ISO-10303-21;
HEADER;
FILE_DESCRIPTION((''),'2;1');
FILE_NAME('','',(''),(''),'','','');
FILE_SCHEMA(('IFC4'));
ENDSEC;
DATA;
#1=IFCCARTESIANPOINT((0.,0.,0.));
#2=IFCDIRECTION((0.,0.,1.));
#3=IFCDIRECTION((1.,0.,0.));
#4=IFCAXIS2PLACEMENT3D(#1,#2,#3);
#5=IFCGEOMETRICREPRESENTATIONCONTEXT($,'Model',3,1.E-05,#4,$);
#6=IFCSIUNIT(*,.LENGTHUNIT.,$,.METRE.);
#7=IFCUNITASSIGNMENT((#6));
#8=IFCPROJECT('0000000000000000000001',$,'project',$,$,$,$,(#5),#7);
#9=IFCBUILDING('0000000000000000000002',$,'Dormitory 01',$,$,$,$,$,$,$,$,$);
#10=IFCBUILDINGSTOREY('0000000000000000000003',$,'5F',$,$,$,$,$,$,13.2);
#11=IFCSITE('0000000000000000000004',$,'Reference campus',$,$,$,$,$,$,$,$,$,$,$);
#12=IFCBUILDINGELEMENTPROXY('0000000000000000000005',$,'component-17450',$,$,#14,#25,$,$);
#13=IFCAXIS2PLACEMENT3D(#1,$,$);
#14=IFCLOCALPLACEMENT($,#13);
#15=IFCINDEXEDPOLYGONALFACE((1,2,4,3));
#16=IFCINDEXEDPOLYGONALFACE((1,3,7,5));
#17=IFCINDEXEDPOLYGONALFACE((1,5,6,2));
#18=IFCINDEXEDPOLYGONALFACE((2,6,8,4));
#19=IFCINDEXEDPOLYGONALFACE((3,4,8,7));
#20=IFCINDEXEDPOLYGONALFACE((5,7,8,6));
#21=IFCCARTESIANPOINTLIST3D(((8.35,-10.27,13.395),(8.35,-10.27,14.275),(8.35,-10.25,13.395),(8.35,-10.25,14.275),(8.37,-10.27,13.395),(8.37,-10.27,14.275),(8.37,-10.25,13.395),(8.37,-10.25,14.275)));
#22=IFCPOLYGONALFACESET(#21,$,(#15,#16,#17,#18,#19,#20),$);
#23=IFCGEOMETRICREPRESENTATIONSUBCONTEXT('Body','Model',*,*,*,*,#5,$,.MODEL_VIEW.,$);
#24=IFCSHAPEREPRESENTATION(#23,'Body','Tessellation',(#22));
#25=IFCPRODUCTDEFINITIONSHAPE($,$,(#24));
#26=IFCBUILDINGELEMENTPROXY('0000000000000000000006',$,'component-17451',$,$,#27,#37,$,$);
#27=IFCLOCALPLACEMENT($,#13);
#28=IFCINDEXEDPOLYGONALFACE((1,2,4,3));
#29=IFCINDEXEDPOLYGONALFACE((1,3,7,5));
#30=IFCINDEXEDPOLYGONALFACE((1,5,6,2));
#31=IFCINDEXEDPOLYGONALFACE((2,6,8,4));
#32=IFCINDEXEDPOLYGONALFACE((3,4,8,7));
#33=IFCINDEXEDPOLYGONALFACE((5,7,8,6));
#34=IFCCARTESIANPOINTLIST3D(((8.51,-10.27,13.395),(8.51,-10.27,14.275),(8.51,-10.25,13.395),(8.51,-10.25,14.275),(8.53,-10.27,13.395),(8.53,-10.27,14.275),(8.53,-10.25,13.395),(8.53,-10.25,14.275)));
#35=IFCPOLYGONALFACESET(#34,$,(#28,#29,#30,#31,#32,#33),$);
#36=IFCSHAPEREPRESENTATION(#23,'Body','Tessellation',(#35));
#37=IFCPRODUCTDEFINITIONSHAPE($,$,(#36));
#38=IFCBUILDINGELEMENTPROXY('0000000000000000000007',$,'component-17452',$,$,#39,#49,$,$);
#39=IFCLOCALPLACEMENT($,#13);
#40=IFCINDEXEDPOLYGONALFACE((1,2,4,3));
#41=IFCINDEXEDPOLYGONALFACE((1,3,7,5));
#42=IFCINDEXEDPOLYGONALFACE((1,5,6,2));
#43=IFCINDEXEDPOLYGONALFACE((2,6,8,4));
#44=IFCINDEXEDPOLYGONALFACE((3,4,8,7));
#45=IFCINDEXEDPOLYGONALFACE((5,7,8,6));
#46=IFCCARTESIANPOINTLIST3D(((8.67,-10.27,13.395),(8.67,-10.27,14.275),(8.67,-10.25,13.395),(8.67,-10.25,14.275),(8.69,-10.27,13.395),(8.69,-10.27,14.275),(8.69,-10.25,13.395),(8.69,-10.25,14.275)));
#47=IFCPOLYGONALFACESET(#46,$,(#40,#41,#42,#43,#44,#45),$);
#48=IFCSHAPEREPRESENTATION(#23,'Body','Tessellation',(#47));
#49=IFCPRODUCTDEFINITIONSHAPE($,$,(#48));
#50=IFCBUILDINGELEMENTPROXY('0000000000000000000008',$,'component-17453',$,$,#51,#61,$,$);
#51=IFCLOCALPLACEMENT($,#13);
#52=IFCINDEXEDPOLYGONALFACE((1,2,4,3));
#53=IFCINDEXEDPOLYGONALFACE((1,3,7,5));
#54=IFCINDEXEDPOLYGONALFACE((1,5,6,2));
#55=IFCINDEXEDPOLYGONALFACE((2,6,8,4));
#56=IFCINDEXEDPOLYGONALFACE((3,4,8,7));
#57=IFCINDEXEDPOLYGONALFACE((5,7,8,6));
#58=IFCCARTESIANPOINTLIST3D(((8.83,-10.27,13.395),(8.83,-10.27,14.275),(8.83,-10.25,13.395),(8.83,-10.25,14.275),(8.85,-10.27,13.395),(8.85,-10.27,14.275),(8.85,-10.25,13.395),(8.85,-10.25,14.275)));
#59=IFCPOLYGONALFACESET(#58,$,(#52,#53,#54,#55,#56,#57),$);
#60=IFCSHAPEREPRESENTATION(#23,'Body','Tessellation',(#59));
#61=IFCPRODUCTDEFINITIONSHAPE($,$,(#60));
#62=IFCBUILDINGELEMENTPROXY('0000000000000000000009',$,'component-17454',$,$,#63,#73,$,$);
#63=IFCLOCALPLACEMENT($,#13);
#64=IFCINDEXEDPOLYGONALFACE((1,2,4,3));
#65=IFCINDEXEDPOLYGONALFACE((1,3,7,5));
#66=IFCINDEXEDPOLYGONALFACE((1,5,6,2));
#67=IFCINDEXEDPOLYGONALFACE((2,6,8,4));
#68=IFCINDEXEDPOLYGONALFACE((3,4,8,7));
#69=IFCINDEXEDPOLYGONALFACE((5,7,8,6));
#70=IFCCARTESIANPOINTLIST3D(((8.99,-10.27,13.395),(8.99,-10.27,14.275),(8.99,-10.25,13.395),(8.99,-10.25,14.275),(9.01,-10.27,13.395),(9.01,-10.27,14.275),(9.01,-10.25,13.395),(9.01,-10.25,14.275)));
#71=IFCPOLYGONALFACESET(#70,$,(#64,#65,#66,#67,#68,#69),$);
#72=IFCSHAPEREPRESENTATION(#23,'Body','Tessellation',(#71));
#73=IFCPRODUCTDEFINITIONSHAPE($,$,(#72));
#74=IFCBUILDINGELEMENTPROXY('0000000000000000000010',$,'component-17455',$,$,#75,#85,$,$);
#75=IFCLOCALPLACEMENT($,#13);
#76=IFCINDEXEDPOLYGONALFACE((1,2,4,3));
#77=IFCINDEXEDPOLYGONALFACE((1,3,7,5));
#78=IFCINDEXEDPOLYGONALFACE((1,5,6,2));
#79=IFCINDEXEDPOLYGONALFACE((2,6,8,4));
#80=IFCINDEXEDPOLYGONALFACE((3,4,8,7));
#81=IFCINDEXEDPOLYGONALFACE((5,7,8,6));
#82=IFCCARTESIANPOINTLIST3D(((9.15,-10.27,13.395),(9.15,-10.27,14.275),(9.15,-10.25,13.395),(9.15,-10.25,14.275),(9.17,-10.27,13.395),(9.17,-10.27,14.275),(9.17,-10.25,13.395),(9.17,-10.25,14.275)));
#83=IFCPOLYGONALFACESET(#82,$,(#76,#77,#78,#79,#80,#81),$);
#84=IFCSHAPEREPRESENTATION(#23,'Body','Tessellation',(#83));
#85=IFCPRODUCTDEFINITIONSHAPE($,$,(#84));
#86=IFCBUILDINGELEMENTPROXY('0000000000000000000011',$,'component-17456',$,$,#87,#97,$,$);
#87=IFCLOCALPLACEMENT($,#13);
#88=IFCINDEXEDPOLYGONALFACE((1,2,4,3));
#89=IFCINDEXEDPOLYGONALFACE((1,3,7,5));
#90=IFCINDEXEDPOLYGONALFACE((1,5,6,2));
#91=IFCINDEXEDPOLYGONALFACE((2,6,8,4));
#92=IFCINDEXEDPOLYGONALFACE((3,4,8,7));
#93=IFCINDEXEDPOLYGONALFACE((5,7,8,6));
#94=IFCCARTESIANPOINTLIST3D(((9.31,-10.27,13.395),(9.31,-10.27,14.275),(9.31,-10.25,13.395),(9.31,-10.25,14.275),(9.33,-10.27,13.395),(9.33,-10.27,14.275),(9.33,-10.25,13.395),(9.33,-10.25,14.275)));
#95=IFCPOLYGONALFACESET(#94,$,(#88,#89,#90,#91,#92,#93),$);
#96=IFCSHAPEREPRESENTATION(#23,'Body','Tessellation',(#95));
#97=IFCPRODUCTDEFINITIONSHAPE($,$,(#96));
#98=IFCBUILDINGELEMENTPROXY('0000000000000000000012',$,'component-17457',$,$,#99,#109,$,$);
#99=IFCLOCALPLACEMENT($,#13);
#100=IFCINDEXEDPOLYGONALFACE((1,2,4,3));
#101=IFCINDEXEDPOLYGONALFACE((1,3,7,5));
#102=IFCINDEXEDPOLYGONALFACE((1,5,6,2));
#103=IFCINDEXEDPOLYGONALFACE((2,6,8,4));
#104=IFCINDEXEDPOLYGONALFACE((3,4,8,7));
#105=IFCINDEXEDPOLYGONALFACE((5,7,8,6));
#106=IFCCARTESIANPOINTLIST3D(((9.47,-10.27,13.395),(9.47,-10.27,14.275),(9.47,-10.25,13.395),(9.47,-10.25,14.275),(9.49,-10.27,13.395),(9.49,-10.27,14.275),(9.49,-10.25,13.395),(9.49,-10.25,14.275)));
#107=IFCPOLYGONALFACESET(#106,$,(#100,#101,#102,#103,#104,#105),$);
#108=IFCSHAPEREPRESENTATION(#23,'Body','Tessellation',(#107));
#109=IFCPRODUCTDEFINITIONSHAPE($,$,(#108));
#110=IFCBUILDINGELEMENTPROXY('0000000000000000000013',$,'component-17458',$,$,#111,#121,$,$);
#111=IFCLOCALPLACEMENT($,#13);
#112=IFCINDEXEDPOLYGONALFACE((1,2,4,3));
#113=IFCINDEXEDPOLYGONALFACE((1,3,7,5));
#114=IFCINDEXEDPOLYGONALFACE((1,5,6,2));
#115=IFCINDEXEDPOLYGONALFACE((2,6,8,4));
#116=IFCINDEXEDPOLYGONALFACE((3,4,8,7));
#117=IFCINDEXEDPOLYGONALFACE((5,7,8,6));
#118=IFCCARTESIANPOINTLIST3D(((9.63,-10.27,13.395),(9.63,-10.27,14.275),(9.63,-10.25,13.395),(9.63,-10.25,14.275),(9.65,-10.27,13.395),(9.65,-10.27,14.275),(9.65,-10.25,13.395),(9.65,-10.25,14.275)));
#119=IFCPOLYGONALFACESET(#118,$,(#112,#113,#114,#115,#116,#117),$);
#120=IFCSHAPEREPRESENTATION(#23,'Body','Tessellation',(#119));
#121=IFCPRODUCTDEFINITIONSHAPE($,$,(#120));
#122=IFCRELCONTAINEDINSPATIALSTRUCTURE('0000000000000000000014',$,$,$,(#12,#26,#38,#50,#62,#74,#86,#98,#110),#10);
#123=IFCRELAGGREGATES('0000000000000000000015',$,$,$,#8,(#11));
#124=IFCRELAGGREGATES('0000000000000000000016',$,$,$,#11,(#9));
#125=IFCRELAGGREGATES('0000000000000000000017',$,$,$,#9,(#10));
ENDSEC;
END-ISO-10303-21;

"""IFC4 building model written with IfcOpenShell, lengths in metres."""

from ifc_helpers import new_model, si_unit, frame, origin, origin_with_axes, origin_2d, place, context, subcontext, project, spatial, rectangle, extrude, element, save


model = new_model("IFC4")

# Units and contexts
model_context = context("Model", 3, precision=1e-05, world=origin_with_axes())
body_context = subcontext(model_context, "Body", "Model", "MODEL_VIEW")
ifc_project = project(units=[si_unit("LENGTHUNIT", "METRE")], contexts=[model_context])

# Site, building, storey
site = spatial("IfcSite", under=ifc_project, Name="Reference campus")
building = spatial("IfcBuilding", under=site, Name="Dormitory 01")
storey = spatial("IfcBuildingStorey", under=building, Name="5F", Elevation=13.2)

# Building element proxies
for number, where, z_axis, x_axis, name in (
    (1, (8.36, -10.26, 13.395), (0.0, 0.0, 1.0), (1.0, 0.0, 0.0), "component-17450"),
    (2, (8.52, -10.26, 13.395), (0.0, 0.0, 1.0), (1.0, 0.0, 0.0), "component-17451"),
    (3, (8.68, -10.26, 13.395), (0.0, 0.0, 1.0), (1.0, 0.0, 0.0), "component-17452"),
    (4, (8.84, -10.26, 13.395), (0.0, 0.0, 1.0), (1.0, 0.0, 0.0), "component-17453"),
    (5, (9.0, -10.26, 13.395), (0.0, 0.0, 1.0), (1.0, 0.0, 0.0), "component-17454"),
    (6, (9.16, -10.26, 13.395), (0.0, 0.0, 1.0), (1.0, 0.0, 0.0), "component-17455"),
    (7, (9.32, -10.26, 13.395), (0.0, 0.0, 1.0), (1.0, 0.0, 0.0), "component-17456"),
    (8, (9.48, -10.26, 13.395), (0.0, 0.0, 1.0), (1.0, 0.0, 0.0), "component-17457"),
    (9, (9.64, -10.26, 13.395), (0.0, 0.0, 1.0), (1.0, 0.0, 0.0), "component-17458"),
):
    element("IfcBuildingElementProxy", number, at=place(None, frame(where, z_axis=z_axis, x_axis=x_axis)), inside=storey, Name=name, context=body_context, shape_type="SweptSolid", body=[
        extrude(rectangle(XDim=0.02, YDim=0.02, at=origin_2d()), origin(), (0.0, 0.0, 1.0), 0.88),
    ])

save(model, "model.ifc")
